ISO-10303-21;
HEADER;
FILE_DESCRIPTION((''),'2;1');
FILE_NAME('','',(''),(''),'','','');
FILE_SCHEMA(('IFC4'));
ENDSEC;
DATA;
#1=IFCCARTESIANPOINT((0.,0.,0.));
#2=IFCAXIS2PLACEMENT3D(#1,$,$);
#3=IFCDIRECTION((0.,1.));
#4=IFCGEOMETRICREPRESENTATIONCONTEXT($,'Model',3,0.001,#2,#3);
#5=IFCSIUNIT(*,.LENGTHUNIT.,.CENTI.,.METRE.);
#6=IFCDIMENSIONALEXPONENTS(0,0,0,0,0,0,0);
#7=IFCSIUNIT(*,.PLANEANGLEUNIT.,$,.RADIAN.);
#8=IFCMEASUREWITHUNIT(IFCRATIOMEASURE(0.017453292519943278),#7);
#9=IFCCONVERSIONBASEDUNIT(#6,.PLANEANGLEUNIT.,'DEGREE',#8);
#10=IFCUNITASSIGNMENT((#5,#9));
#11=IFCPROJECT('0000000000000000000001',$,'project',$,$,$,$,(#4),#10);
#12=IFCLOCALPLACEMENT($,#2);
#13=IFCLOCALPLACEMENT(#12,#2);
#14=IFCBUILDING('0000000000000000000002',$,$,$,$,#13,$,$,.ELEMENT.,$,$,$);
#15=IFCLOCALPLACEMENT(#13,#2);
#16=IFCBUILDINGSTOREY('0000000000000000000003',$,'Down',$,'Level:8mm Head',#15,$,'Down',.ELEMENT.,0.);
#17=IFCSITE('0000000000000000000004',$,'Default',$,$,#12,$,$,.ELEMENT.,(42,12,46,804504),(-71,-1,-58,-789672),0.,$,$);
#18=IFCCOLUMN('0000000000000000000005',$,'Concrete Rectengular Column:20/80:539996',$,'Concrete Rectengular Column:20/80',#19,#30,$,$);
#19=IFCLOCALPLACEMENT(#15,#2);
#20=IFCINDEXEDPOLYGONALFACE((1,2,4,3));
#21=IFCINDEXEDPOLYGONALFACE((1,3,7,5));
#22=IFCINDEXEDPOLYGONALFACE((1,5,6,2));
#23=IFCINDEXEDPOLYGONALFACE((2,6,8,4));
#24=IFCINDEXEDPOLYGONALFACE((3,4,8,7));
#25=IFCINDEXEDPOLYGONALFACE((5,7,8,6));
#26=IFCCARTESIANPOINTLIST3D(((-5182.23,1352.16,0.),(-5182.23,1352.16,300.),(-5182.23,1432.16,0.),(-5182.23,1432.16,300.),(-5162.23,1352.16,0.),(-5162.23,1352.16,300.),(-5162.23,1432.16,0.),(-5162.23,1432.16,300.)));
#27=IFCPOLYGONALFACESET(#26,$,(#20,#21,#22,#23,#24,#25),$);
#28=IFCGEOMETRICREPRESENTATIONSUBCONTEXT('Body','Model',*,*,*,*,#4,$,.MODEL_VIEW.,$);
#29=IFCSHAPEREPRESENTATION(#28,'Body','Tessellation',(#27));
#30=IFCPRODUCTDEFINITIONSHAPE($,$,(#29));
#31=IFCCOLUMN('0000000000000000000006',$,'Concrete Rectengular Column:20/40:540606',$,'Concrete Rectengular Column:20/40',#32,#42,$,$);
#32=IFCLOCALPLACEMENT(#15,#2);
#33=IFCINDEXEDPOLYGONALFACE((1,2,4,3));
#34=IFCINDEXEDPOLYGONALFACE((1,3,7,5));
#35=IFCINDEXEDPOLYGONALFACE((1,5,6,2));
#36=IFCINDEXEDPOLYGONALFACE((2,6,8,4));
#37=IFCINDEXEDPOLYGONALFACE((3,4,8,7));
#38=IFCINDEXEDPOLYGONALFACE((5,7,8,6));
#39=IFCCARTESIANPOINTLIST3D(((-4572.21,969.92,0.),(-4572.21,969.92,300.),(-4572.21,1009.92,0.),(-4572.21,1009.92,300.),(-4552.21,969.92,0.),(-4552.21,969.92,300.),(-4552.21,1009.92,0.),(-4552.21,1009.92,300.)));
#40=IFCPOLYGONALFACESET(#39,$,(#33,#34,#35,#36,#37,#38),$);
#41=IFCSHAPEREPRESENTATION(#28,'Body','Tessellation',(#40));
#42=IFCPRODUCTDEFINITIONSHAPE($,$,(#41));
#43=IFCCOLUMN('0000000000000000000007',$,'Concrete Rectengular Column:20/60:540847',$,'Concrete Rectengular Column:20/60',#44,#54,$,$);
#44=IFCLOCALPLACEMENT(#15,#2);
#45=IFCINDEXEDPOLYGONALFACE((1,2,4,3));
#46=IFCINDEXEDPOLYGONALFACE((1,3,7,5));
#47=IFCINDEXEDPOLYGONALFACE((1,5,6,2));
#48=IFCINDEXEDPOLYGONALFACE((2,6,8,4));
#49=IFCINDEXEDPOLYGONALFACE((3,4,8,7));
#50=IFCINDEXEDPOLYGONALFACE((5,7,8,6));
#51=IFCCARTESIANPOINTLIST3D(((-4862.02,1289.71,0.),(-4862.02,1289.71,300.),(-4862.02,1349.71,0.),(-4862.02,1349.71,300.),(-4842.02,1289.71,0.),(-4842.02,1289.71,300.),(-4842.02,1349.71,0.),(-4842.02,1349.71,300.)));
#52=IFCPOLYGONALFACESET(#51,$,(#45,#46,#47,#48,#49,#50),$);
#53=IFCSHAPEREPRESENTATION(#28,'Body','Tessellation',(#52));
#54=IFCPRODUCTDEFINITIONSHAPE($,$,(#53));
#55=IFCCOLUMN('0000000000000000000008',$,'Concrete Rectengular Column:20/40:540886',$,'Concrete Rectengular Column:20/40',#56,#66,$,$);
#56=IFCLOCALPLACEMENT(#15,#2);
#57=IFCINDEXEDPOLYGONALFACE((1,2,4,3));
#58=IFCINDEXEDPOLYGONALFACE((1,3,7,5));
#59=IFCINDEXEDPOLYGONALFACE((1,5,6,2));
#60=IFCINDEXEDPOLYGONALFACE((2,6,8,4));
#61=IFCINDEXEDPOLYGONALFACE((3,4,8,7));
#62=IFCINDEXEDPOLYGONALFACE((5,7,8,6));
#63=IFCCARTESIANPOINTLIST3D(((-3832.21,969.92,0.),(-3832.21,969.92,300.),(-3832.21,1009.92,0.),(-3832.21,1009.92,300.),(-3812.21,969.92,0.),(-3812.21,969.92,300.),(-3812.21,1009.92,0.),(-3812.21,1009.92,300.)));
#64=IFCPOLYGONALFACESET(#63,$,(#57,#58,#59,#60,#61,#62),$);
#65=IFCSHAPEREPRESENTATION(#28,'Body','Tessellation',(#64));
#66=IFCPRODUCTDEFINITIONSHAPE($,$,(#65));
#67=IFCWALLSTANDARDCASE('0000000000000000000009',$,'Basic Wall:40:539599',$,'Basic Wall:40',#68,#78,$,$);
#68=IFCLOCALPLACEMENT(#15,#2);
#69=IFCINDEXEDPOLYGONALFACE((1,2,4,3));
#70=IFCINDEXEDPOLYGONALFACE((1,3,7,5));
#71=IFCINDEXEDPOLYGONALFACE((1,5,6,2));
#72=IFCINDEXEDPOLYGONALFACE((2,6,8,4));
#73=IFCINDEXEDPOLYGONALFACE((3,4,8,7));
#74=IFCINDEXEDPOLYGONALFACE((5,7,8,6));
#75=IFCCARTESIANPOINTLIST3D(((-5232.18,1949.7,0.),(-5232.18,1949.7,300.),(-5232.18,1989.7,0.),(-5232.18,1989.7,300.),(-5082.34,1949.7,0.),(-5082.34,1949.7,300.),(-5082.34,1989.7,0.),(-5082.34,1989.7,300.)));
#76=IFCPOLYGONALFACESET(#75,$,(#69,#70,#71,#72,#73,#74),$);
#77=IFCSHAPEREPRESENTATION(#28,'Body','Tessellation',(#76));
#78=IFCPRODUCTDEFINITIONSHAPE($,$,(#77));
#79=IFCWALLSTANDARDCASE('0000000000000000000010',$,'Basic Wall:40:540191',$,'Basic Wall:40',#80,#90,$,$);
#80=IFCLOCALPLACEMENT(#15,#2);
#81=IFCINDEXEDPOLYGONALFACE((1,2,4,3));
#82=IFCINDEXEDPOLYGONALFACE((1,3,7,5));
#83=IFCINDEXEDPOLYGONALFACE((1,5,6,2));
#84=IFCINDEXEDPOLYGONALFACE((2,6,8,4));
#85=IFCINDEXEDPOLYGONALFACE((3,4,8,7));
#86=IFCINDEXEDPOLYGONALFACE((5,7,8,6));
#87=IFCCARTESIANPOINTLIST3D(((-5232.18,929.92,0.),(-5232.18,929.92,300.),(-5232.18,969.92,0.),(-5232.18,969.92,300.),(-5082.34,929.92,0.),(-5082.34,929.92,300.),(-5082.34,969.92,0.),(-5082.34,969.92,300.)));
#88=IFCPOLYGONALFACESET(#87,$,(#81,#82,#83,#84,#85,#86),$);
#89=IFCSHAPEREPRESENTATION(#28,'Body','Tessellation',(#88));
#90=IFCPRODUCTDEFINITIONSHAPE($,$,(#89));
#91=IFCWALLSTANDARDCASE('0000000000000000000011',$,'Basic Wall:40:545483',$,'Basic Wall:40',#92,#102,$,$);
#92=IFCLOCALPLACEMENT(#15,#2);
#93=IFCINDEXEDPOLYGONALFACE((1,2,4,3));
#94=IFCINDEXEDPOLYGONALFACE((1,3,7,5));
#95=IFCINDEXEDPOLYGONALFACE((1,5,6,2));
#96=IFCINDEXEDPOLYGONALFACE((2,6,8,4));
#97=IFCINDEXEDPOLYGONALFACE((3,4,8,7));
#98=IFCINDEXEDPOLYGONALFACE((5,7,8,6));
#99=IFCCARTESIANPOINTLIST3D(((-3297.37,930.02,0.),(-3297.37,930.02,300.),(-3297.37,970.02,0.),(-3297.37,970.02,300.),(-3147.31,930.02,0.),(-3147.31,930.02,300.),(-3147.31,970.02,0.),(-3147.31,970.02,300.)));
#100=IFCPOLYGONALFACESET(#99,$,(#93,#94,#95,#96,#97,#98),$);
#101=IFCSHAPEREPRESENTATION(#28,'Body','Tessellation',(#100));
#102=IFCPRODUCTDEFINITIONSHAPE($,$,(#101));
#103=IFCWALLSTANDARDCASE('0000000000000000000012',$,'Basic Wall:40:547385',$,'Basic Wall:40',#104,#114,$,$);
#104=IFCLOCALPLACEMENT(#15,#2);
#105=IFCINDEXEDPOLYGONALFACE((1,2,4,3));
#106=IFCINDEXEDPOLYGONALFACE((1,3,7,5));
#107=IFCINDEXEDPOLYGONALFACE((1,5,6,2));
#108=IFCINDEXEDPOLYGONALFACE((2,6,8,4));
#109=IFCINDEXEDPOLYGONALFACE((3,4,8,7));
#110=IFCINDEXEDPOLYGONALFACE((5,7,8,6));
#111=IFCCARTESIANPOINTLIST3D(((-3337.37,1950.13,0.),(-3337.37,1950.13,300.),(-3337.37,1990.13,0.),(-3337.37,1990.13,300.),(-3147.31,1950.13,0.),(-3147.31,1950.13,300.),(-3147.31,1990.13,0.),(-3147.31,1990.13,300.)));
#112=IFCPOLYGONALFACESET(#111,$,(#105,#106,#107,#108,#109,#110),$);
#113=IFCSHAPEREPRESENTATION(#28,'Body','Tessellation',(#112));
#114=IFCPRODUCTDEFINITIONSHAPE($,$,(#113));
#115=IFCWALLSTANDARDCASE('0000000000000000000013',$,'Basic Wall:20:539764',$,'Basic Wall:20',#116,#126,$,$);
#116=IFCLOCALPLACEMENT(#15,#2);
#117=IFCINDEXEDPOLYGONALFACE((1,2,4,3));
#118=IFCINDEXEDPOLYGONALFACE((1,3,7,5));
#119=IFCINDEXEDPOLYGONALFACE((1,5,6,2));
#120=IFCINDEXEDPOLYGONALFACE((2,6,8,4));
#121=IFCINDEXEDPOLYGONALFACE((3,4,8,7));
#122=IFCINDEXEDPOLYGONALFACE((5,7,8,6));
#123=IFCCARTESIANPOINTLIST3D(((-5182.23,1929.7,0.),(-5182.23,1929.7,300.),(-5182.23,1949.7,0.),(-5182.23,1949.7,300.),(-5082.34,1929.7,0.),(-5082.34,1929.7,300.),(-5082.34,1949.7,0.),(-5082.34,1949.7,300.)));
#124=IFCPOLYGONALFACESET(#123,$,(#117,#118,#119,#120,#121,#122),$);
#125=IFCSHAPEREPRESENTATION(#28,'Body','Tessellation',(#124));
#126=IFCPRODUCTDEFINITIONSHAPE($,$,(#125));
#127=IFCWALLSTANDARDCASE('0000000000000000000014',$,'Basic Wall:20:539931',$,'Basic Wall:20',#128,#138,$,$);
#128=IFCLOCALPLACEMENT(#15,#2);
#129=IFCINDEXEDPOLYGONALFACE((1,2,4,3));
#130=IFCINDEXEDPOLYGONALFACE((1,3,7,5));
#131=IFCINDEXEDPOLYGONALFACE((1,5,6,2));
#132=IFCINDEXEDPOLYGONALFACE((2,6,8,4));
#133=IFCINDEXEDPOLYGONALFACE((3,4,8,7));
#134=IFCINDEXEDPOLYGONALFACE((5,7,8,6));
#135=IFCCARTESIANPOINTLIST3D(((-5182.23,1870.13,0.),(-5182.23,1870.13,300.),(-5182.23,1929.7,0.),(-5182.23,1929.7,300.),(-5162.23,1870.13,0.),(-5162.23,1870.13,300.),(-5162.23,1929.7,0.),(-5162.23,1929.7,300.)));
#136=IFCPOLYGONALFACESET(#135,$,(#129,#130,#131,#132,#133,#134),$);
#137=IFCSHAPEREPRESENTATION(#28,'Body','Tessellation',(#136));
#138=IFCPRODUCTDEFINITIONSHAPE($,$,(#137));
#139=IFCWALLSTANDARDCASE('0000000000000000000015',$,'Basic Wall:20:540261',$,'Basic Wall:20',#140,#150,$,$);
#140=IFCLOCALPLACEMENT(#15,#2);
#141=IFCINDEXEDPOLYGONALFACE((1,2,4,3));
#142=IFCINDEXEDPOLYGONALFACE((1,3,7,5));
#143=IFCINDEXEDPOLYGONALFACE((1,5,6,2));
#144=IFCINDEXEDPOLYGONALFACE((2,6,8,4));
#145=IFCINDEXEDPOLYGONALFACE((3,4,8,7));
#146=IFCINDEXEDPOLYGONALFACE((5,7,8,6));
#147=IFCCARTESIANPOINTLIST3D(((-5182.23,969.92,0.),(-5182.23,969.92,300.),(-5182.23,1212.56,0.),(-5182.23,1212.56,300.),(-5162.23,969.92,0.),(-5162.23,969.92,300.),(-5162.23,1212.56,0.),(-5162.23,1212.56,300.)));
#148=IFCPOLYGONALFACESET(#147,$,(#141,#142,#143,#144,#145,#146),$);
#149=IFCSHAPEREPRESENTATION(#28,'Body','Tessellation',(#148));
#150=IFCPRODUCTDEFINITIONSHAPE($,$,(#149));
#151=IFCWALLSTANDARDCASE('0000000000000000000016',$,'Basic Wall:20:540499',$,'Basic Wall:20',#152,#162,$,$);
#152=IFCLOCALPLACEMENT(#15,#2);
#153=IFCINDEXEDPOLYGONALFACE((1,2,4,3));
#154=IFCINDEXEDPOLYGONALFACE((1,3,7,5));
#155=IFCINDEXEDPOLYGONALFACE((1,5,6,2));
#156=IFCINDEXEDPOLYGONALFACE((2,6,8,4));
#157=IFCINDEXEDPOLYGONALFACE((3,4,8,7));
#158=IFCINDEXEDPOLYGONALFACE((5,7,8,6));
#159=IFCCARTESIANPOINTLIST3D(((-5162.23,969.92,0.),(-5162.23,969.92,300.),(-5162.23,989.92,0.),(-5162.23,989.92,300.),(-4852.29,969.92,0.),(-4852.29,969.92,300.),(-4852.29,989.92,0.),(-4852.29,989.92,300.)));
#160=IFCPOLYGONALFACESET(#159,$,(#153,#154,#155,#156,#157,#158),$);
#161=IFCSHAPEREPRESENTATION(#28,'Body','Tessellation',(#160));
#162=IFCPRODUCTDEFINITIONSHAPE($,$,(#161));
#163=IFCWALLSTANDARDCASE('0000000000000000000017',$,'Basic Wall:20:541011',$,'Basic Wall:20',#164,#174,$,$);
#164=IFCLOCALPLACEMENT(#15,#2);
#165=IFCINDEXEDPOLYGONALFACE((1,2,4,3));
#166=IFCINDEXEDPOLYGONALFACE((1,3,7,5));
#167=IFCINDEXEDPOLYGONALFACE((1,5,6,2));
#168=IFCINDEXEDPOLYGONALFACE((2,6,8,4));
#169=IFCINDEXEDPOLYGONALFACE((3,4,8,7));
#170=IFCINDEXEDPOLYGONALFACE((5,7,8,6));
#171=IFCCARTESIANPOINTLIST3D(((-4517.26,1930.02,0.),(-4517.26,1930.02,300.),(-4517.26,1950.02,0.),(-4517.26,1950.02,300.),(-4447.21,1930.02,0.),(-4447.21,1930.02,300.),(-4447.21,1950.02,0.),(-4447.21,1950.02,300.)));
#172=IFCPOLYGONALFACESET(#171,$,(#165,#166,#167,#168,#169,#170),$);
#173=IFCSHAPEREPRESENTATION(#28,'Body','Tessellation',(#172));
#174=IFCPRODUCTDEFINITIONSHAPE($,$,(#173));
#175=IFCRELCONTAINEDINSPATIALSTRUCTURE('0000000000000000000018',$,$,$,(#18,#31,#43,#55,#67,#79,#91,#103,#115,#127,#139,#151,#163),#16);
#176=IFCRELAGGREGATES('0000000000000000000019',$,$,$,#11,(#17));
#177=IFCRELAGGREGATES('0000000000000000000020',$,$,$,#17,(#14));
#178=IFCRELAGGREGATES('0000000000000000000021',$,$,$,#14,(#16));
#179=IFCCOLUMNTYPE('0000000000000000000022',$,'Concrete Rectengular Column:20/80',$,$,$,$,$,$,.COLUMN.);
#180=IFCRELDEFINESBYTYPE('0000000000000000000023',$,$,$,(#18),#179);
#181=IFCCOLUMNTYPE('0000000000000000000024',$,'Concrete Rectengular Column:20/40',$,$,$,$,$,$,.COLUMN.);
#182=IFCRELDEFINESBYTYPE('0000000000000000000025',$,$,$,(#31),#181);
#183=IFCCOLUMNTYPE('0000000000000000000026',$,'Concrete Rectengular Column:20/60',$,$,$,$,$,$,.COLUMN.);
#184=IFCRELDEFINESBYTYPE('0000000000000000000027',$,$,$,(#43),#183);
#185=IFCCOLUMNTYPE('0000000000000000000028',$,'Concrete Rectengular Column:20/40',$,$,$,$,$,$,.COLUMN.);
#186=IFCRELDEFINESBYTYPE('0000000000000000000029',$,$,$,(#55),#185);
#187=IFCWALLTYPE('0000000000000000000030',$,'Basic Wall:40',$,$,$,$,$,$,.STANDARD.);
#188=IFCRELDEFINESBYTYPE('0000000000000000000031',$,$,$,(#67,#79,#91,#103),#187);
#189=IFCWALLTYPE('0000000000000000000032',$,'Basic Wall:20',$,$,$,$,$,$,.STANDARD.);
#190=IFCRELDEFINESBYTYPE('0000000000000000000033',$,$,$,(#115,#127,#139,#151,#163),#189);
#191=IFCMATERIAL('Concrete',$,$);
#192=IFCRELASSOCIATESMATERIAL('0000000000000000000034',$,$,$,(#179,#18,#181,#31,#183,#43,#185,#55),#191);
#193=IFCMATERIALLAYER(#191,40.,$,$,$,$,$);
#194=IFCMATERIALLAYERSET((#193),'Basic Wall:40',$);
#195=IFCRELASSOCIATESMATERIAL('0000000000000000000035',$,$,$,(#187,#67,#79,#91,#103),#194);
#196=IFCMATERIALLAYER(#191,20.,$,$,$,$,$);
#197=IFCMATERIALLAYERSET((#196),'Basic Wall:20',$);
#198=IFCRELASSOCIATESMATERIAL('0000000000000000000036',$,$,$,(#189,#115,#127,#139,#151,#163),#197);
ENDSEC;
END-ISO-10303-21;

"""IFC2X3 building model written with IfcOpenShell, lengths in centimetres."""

from ifc_helpers import new_model, entity, si_unit, converted_unit, direction, frame, frame_2d, origin, origin_2d_with_axis, place, context, subcontext, project, spatial, rectangle, extrude, source, transform, mapped, material, layer, layer_set, layer_usage, type_object, type_shapes, element, save


model = new_model("IFC2X3")

# Units and contexts
model_context = context("Model", 3, precision=0.001, world=origin(), true_north=direction((0.0, 1.0)))
body_context = subcontext(model_context, "Body", "Model", "MODEL_VIEW")
ifc_project = project(units=[si_unit("LENGTHUNIT", "METRE", prefix="CENTI"), converted_unit("PLANEANGLEUNIT", "DEGREE", entity("IfcRatioMeasure", 0.017453292519943278), si_unit("PLANEANGLEUNIT", "RADIAN"), dimensions=[0, 0, 0, 0, 0, 0, 0])], contexts=[model_context])

# Site, building, storey
site_placement = place(None, origin())
site = spatial("IfcSite", under=ifc_project, at=site_placement, Name="Default", CompositionType="ELEMENT", RefLatitude=(42, 12, 46, 804504), RefLongitude=(-71, -1, -58, -789672), RefElevation=0.0)
building_placement = place(site_placement, origin())
building = spatial("IfcBuilding", under=site, at=building_placement, CompositionType="ELEMENT")
storey_placement = place(building_placement, origin())
storey = spatial("IfcBuildingStorey", under=building, at=storey_placement, Name="Down", ObjectType="Level:8mm Head", LongName="Down", CompositionType="ELEMENT", Elevation=0.0)

# Columns
ifc_material = material(Name="Concrete")
column_type_1 = type_object("IfcColumnType", Name="Concrete Rectengular Column:20/80", PredefinedType="COLUMN", material=ifc_material)
shared_shape_1 = source(origin(), body_context, "Body", "SweptSolid", [
    extrude(rectangle(XDim=80.0, YDim=20.0, at=origin_2d_with_axis()), frame((-5172.23, 1392.16, 0.0), z_axis=(0.0, 0.0, 1.0), x_axis=(0.0, -1.0, 0.0)), (0.0, 0.0, 1.0), 300.0),
])
type_shapes(column_type_1, [shared_shape_1])
column_1_placement = place(storey_placement, origin())
element("IfcColumn", 1, at=column_1_placement, inside=storey, type_object=column_type_1, material=ifc_material, Name="Concrete Rectengular Column:20/80:539996", ObjectType="Concrete Rectengular Column:20/80", context=body_context, shape_type="MappedRepresentation", body=[
    mapped(shared_shape_1, transform((0.0, 0.0, 0.0), scale=1.0)),
])
column_type_2 = type_object("IfcColumnType", Name="Concrete Rectengular Column:20/40", PredefinedType="COLUMN", material=ifc_material)
shared_shape_2 = source(origin(), body_context, "Body", "SweptSolid", [
    extrude(rectangle(XDim=40.0, YDim=20.0, at=origin_2d_with_axis()), frame((-4562.21, 989.92, 0.0), z_axis=(0.0, 0.0, 1.0), x_axis=(0.0, -1.0, 0.0)), (0.0, 0.0, 1.0), 300.0),
])
type_shapes(column_type_2, [shared_shape_2])
column_2_placement = place(storey_placement, origin())
element("IfcColumn", 2, at=column_2_placement, inside=storey, type_object=column_type_2, material=ifc_material, Name="Concrete Rectengular Column:20/40:540606", ObjectType="Concrete Rectengular Column:20/40", context=body_context, shape_type="MappedRepresentation", body=[
    mapped(shared_shape_2, transform((0.0, 0.0, 0.0), scale=1.0)),
])
column_type_3 = type_object("IfcColumnType", Name="Concrete Rectengular Column:20/60", PredefinedType="COLUMN", material=ifc_material)
shared_shape_3 = source(origin(), body_context, "Body", "SweptSolid", [
    extrude(rectangle(XDim=60.0, YDim=20.0, at=frame_2d((0.0, 0.0), x_axis=(1.0, 0.0))), frame((-4852.02, 1319.71, 0.0), z_axis=(0.0, 0.0, 1.0), x_axis=(0.0, -1.0, 0.0)), (0.0, 0.0, 1.0), 300.0),
])
type_shapes(column_type_3, [shared_shape_3])
column_3_placement = place(storey_placement, origin())
element("IfcColumn", 3, at=column_3_placement, inside=storey, type_object=column_type_3, material=ifc_material, Name="Concrete Rectengular Column:20/60:540847", ObjectType="Concrete Rectengular Column:20/60", context=body_context, shape_type="MappedRepresentation", body=[
    mapped(shared_shape_3, transform((0.0, 0.0, 0.0), scale=1.0)),
])
column_type_4 = type_object("IfcColumnType", Name="Concrete Rectengular Column:20/40", PredefinedType="COLUMN", material=ifc_material)
shared_shape_4 = source(origin(), body_context, "Body", "SweptSolid", [
    extrude(rectangle(XDim=40.0, YDim=20.0, at=origin_2d_with_axis()), frame((-3822.21, 989.92, 0.0), z_axis=(0.0, 0.0, 1.0), x_axis=(0.0, -1.0, 0.0)), (0.0, 0.0, 1.0), 300.0),
])
type_shapes(column_type_4, [shared_shape_4])
column_4_placement = place(storey_placement, origin())
element("IfcColumn", 4, at=column_4_placement, inside=storey, type_object=column_type_4, material=ifc_material, Name="Concrete Rectengular Column:20/40:540886", ObjectType="Concrete Rectengular Column:20/40", context=body_context, shape_type="MappedRepresentation", body=[
    mapped(shared_shape_4, transform((0.0, 0.0, 0.0), scale=1.0)),
])

# Walls
ifc_layer_1 = layer(ifc_material, 40.0)
ifc_layer_set_1 = layer_set([ifc_layer_1], Name="Basic Wall:40")
ifc_layer_usage_1 = layer_usage(ifc_layer_set_1, "AXIS2", "NEGATIVE", 20.0)
wall_type_1 = type_object("IfcWallType", Name="Basic Wall:40", PredefinedType="STANDARD", material=ifc_layer_set_1)
wall_1_placement = place(storey_placement, frame((-5232.18, 1969.7, 0.0)))
element("IfcWallStandardCase", 5, at=wall_1_placement, inside=storey, type_object=wall_type_1, material=ifc_layer_usage_1, Name="Basic Wall:40:539599", ObjectType="Basic Wall:40", context=body_context, shape_type="SweptSolid", body=[
    extrude(rectangle(XDim=149.84, YDim=40.0, at=frame_2d((74.92, 0.0), x_axis=(-1.0, 0.0))), origin(), (0.0, 0.0, 1.0), 300.0),
])
ifc_layer_usage_2 = layer_usage(ifc_layer_set_1, "AXIS2", "POSITIVE", -20.0)
wall_2_placement = place(storey_placement, frame((-5232.18, 949.92, 0.0)))
element("IfcWallStandardCase", 6, at=wall_2_placement, inside=storey, type_object=wall_type_1, material=ifc_layer_usage_2, Name="Basic Wall:40:540191", ObjectType="Basic Wall:40", context=body_context, shape_type="SweptSolid", body=[
    extrude(rectangle(XDim=149.84, YDim=40.0, at=frame_2d((74.92, 0.0), x_axis=(-1.0, 0.0))), origin(), (0.0, 0.0, 1.0), 300.0),
])
ifc_layer_usage_3 = layer_usage(ifc_layer_set_1, "AXIS2", "NEGATIVE", 20.0)
wall_3_placement = place(storey_placement, frame((-3147.31, 950.02, 0.0), z_axis=(0.0, 0.0, 1.0), x_axis=(-1.0, 0.0, 0.0)))
element("IfcWallStandardCase", 7, at=wall_3_placement, inside=storey, type_object=wall_type_1, material=ifc_layer_usage_3, Name="Basic Wall:40:545483", ObjectType="Basic Wall:40", context=body_context, shape_type="SweptSolid", body=[
    extrude(rectangle(XDim=150.05, YDim=40.0, at=frame_2d((75.03, 0.0), x_axis=(-1.0, 0.0))), origin(), (0.0, 0.0, 1.0), 300.0),
])
ifc_layer_usage_4 = layer_usage(ifc_layer_set_1, "AXIS2", "POSITIVE", -20.0)
wall_4_placement = place(storey_placement, frame((-3147.31, 1970.13, 0.0), z_axis=(0.0, 0.0, 1.0), x_axis=(-1.0, 0.0, 0.0)))
element("IfcWallStandardCase", 8, at=wall_4_placement, inside=storey, type_object=wall_type_1, material=ifc_layer_usage_4, Name="Basic Wall:40:547385", ObjectType="Basic Wall:40", context=body_context, shape_type="SweptSolid", body=[
    extrude(rectangle(XDim=190.05, YDim=40.0, at=frame_2d((95.03, 0.0), x_axis=(-1.0, 0.0))), origin(), (0.0, 0.0, 1.0), 300.0),
])
ifc_layer_2 = layer(ifc_material, 20.0)
ifc_layer_set_2 = layer_set([ifc_layer_2], Name="Basic Wall:20")
ifc_layer_usage_5 = layer_usage(ifc_layer_set_2, "AXIS2", "POSITIVE", -10.0)
wall_type_2 = type_object("IfcWallType", Name="Basic Wall:20", PredefinedType="STANDARD", material=ifc_layer_set_2)
wall_5_placement = place(storey_placement, frame((-5082.34, 1939.7, 0.0), z_axis=(0.0, 0.0, 1.0), x_axis=(-1.0, 0.0, 0.0)))
element("IfcWallStandardCase", 9, at=wall_5_placement, inside=storey, type_object=wall_type_2, material=ifc_layer_usage_5, Name="Basic Wall:20:539764", ObjectType="Basic Wall:20", context=body_context, shape_type="SweptSolid", body=[
    extrude(rectangle(XDim=99.89, YDim=20.0, at=frame_2d((49.95, 0.0), x_axis=(-1.0, 0.0))), origin(), (0.0, 0.0, 1.0), 300.0),
])
ifc_layer_usage_6 = layer_usage(ifc_layer_set_2, "AXIS2", "POSITIVE", -10.0)
wall_6_placement = place(storey_placement, frame((-5172.23, 1929.7, 0.0), z_axis=(0.0, 0.0, 1.0), x_axis=(0.0, -1.0, 0.0)))
element("IfcWallStandardCase", 10, at=wall_6_placement, inside=storey, type_object=wall_type_2, material=ifc_layer_usage_6, Name="Basic Wall:20:539931", ObjectType="Basic Wall:20", context=body_context, shape_type="SweptSolid", body=[
    extrude(rectangle(XDim=59.58, YDim=20.0, at=frame_2d((29.79, 0.0), x_axis=(-1.0, 0.0))), origin(), (0.0, 0.0, 1.0), 300.0),
])
ifc_layer_usage_7 = layer_usage(ifc_layer_set_2, "AXIS2", "POSITIVE", -10.0)
wall_7_placement = place(storey_placement, frame((-5172.23, 1212.56, 0.0), z_axis=(0.0, 0.0, 1.0), x_axis=(0.0, -1.0, 0.0)))
element("IfcWallStandardCase", 11, at=wall_7_placement, inside=storey, type_object=wall_type_2, material=ifc_layer_usage_7, Name="Basic Wall:20:540261", ObjectType="Basic Wall:20", context=body_context, shape_type="SweptSolid", body=[
    extrude(rectangle(XDim=242.65, YDim=20.0, at=frame_2d((121.32, 0.0), x_axis=(-1.0, 0.0))), origin(), (0.0, 0.0, 1.0), 300.0),
])
ifc_layer_usage_8 = layer_usage(ifc_layer_set_2, "AXIS2", "NEGATIVE", 10.0)
wall_8_placement = place(storey_placement, frame((-5162.23, 979.92, 0.0)))
element("IfcWallStandardCase", 12, at=wall_8_placement, inside=storey, type_object=wall_type_2, material=ifc_layer_usage_8, Name="Basic Wall:20:540499", ObjectType="Basic Wall:20", context=body_context, shape_type="SweptSolid", body=[
    extrude(rectangle(XDim=309.95, YDim=20.0, at=frame_2d((154.97, 0.0), x_axis=(-1.0, 0.0))), origin(), (0.0, 0.0, 1.0), 300.0),
])
ifc_layer_usage_9 = layer_usage(ifc_layer_set_2, "AXIS2", "POSITIVE", -10.0)
wall_9_placement = place(storey_placement, frame((-4517.26, 1940.02, 0.0)))
element("IfcWallStandardCase", 13, at=wall_9_placement, inside=storey, type_object=wall_type_2, material=ifc_layer_usage_9, Name="Basic Wall:20:541011", ObjectType="Basic Wall:20", context=body_context, shape_type="SweptSolid", body=[
    extrude(rectangle(XDim=70.05, YDim=20.0, at=frame_2d((35.03, 0.0), x_axis=(-1.0, 0.0))), origin(), (0.0, 0.0, 1.0), 300.0),
])

save(model, "model.ifc")
